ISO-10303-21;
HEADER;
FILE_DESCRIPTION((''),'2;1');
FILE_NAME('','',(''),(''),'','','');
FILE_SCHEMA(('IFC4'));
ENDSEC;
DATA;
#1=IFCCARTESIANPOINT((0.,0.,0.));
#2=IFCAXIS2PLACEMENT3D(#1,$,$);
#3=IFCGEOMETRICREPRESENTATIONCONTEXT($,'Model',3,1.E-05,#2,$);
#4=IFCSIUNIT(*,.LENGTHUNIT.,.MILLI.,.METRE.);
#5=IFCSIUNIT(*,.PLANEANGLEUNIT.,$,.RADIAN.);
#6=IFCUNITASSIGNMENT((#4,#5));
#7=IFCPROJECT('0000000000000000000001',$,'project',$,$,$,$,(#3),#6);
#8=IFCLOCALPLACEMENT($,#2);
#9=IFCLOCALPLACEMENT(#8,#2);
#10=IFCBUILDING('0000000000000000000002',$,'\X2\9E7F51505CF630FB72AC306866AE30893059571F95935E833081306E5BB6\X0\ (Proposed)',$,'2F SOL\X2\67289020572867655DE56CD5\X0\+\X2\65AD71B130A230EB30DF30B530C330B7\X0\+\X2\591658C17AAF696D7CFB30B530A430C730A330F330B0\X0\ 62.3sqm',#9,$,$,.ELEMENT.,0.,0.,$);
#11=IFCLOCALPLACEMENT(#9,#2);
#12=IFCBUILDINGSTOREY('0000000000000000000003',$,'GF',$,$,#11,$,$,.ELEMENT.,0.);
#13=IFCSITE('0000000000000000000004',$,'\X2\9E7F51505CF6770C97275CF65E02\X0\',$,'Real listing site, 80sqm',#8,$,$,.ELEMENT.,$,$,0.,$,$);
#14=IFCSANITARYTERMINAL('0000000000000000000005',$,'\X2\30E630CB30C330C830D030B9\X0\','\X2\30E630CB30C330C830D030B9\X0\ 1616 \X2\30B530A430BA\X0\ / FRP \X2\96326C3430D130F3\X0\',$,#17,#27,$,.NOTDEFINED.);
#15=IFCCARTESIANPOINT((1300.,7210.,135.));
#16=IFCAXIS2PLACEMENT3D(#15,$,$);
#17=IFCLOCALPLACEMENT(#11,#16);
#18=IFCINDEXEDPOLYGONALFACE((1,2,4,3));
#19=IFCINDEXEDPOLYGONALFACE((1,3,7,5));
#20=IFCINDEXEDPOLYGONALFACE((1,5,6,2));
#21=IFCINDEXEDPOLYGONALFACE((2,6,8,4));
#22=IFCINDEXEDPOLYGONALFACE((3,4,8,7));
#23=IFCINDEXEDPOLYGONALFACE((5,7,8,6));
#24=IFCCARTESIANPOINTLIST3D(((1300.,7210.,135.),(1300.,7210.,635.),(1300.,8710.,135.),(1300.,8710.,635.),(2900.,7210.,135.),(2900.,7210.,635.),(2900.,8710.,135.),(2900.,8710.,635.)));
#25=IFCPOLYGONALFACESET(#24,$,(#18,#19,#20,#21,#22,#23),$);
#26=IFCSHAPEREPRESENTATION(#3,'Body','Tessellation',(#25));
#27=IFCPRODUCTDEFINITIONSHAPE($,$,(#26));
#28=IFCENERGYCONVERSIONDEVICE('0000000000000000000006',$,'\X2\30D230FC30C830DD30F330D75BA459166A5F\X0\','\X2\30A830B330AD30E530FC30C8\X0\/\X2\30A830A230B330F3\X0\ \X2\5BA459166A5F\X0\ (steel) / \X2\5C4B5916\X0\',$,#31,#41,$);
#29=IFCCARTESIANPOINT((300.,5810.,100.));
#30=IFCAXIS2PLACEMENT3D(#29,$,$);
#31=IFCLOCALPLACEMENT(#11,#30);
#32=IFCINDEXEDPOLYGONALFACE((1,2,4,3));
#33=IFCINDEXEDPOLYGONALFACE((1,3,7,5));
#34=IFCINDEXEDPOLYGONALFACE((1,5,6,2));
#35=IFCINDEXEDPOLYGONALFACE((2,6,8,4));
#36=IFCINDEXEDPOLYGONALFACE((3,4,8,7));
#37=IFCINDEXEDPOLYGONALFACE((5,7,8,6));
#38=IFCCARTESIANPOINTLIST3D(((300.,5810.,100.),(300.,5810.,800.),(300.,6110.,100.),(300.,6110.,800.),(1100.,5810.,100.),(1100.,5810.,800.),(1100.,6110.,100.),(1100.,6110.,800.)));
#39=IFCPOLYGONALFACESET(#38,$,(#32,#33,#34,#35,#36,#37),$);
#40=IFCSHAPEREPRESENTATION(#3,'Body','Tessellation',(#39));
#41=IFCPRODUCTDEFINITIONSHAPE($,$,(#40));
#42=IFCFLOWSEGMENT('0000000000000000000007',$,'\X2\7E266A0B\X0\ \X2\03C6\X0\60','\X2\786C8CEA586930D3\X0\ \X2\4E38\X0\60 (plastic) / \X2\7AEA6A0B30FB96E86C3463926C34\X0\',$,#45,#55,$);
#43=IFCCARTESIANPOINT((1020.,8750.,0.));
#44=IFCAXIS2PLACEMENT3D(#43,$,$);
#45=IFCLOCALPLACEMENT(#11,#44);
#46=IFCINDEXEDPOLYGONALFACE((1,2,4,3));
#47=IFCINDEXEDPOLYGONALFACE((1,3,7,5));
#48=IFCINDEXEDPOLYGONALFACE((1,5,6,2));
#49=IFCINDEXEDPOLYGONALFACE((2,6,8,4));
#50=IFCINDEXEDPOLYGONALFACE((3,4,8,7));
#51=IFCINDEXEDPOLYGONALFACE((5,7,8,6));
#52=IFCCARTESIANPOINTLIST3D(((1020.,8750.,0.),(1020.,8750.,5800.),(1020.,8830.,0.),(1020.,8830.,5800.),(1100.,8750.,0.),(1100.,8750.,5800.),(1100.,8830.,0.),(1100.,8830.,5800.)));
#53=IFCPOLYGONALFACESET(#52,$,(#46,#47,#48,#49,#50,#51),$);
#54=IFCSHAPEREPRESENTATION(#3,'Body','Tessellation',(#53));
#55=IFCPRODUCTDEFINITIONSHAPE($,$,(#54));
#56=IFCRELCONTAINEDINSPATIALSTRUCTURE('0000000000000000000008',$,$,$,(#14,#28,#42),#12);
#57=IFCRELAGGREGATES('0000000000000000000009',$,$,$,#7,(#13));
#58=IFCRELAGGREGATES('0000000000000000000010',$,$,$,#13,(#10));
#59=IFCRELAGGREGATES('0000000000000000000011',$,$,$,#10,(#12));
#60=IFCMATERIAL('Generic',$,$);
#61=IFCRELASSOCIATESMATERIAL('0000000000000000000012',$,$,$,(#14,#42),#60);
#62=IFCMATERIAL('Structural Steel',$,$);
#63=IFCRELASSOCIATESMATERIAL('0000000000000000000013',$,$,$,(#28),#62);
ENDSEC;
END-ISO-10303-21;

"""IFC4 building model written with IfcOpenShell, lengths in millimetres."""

from ifc_helpers import new_model, si_unit, frame, frame_2d, origin, place, context, project, spatial, rectangle, extrude, material, element, save


model = new_model("IFC4")

# Units and contexts
model_context = context("Model", 3, precision=1e-05, world=origin())
ifc_project = project(units=[si_unit("LENGTHUNIT", "METRE", prefix="MILLI"), si_unit("PLANEANGLEUNIT", "RADIAN")], contexts=[model_context])

# Site, building, storey
site_placement = place(None, origin())
site = spatial("IfcSite", under=ifc_project, at=site_placement, Name="鹿児島県霧島市", ObjectType="Real listing site, 80sqm", CompositionType="ELEMENT", RefElevation=0.0)
building_placement = place(site_placement, origin())
building = spatial("IfcBuilding", under=site, at=building_placement, Name="鹿児島・犬と暮らす土間広めの家 (Proposed)", ObjectType="2F SOL木造在来工法+断熱アルミサッシ+外壁窯業系サイディング 62.3sqm", CompositionType="ELEMENT", ElevationOfRefHeight=0.0, ElevationOfTerrain=0.0)
storey_placement = place(building_placement, origin())
storey = spatial("IfcBuildingStorey", under=building, at=storey_placement, Name="GF", CompositionType="ELEMENT", Elevation=0.0)

# Shared definitions
ifc_material_1 = material(Name="Generic")

# Sanitary terminal
sanitary_terminal_placement = place(storey_placement, frame((1300.0, 7210.0, 135.0)))
element("IfcSanitaryTerminal", 1, at=sanitary_terminal_placement, inside=storey, material=ifc_material_1, Name="ユニットバス", Description="ユニットバス 1616 サイズ / FRP 防水パン", PredefinedType="NOTDEFINED", context=model_context, shape_type="SweptSolid", body=[
    extrude(rectangle(XDim=1600.0, YDim=1500.0, at=frame_2d((800.0, 750.0))), frame((1300.0, 7210.0, 135.0)), (0.0, 0.0, 1.0), 500.0),
])

# Energy conversion device
ifc_material_2 = material(Name="Structural Steel")
energy_conversion_device_placement = place(storey_placement, frame((300.0, 5810.0, 100.0)))
element("IfcEnergyConversionDevice", 2, at=energy_conversion_device_placement, inside=storey, material=ifc_material_2, Name="ヒートポンプ室外機", Description="エコキュート/エアコン 室外機 (steel) / 屋外", context=model_context, shape_type="SweptSolid", body=[
    extrude(rectangle(XDim=800.0, YDim=300.0, at=frame_2d((400.0, 150.0))), frame((300.0, 5810.0, 100.0)), (0.0, 0.0, 1.0), 700.0),
])

# Flow segment
flow_segment_placement = place(storey_placement, frame((1020.0, 8750.0, 0.0)))
element("IfcFlowSegment", 3, at=flow_segment_placement, inside=storey, material=ifc_material_1, Name="縦樋 φ60", Description="硬質塩ビ 丸60 (plastic) / 竪樋・雨水排水", context=model_context, shape_type="SweptSolid", body=[
    extrude(rectangle(XDim=80.0, YDim=80.0, at=frame_2d((40.0, 40.0))), frame((1020.0, 8750.0, 0.0)), (0.0, 0.0, 1.0), 5800.0),
])

save(model, "model.ifc")
